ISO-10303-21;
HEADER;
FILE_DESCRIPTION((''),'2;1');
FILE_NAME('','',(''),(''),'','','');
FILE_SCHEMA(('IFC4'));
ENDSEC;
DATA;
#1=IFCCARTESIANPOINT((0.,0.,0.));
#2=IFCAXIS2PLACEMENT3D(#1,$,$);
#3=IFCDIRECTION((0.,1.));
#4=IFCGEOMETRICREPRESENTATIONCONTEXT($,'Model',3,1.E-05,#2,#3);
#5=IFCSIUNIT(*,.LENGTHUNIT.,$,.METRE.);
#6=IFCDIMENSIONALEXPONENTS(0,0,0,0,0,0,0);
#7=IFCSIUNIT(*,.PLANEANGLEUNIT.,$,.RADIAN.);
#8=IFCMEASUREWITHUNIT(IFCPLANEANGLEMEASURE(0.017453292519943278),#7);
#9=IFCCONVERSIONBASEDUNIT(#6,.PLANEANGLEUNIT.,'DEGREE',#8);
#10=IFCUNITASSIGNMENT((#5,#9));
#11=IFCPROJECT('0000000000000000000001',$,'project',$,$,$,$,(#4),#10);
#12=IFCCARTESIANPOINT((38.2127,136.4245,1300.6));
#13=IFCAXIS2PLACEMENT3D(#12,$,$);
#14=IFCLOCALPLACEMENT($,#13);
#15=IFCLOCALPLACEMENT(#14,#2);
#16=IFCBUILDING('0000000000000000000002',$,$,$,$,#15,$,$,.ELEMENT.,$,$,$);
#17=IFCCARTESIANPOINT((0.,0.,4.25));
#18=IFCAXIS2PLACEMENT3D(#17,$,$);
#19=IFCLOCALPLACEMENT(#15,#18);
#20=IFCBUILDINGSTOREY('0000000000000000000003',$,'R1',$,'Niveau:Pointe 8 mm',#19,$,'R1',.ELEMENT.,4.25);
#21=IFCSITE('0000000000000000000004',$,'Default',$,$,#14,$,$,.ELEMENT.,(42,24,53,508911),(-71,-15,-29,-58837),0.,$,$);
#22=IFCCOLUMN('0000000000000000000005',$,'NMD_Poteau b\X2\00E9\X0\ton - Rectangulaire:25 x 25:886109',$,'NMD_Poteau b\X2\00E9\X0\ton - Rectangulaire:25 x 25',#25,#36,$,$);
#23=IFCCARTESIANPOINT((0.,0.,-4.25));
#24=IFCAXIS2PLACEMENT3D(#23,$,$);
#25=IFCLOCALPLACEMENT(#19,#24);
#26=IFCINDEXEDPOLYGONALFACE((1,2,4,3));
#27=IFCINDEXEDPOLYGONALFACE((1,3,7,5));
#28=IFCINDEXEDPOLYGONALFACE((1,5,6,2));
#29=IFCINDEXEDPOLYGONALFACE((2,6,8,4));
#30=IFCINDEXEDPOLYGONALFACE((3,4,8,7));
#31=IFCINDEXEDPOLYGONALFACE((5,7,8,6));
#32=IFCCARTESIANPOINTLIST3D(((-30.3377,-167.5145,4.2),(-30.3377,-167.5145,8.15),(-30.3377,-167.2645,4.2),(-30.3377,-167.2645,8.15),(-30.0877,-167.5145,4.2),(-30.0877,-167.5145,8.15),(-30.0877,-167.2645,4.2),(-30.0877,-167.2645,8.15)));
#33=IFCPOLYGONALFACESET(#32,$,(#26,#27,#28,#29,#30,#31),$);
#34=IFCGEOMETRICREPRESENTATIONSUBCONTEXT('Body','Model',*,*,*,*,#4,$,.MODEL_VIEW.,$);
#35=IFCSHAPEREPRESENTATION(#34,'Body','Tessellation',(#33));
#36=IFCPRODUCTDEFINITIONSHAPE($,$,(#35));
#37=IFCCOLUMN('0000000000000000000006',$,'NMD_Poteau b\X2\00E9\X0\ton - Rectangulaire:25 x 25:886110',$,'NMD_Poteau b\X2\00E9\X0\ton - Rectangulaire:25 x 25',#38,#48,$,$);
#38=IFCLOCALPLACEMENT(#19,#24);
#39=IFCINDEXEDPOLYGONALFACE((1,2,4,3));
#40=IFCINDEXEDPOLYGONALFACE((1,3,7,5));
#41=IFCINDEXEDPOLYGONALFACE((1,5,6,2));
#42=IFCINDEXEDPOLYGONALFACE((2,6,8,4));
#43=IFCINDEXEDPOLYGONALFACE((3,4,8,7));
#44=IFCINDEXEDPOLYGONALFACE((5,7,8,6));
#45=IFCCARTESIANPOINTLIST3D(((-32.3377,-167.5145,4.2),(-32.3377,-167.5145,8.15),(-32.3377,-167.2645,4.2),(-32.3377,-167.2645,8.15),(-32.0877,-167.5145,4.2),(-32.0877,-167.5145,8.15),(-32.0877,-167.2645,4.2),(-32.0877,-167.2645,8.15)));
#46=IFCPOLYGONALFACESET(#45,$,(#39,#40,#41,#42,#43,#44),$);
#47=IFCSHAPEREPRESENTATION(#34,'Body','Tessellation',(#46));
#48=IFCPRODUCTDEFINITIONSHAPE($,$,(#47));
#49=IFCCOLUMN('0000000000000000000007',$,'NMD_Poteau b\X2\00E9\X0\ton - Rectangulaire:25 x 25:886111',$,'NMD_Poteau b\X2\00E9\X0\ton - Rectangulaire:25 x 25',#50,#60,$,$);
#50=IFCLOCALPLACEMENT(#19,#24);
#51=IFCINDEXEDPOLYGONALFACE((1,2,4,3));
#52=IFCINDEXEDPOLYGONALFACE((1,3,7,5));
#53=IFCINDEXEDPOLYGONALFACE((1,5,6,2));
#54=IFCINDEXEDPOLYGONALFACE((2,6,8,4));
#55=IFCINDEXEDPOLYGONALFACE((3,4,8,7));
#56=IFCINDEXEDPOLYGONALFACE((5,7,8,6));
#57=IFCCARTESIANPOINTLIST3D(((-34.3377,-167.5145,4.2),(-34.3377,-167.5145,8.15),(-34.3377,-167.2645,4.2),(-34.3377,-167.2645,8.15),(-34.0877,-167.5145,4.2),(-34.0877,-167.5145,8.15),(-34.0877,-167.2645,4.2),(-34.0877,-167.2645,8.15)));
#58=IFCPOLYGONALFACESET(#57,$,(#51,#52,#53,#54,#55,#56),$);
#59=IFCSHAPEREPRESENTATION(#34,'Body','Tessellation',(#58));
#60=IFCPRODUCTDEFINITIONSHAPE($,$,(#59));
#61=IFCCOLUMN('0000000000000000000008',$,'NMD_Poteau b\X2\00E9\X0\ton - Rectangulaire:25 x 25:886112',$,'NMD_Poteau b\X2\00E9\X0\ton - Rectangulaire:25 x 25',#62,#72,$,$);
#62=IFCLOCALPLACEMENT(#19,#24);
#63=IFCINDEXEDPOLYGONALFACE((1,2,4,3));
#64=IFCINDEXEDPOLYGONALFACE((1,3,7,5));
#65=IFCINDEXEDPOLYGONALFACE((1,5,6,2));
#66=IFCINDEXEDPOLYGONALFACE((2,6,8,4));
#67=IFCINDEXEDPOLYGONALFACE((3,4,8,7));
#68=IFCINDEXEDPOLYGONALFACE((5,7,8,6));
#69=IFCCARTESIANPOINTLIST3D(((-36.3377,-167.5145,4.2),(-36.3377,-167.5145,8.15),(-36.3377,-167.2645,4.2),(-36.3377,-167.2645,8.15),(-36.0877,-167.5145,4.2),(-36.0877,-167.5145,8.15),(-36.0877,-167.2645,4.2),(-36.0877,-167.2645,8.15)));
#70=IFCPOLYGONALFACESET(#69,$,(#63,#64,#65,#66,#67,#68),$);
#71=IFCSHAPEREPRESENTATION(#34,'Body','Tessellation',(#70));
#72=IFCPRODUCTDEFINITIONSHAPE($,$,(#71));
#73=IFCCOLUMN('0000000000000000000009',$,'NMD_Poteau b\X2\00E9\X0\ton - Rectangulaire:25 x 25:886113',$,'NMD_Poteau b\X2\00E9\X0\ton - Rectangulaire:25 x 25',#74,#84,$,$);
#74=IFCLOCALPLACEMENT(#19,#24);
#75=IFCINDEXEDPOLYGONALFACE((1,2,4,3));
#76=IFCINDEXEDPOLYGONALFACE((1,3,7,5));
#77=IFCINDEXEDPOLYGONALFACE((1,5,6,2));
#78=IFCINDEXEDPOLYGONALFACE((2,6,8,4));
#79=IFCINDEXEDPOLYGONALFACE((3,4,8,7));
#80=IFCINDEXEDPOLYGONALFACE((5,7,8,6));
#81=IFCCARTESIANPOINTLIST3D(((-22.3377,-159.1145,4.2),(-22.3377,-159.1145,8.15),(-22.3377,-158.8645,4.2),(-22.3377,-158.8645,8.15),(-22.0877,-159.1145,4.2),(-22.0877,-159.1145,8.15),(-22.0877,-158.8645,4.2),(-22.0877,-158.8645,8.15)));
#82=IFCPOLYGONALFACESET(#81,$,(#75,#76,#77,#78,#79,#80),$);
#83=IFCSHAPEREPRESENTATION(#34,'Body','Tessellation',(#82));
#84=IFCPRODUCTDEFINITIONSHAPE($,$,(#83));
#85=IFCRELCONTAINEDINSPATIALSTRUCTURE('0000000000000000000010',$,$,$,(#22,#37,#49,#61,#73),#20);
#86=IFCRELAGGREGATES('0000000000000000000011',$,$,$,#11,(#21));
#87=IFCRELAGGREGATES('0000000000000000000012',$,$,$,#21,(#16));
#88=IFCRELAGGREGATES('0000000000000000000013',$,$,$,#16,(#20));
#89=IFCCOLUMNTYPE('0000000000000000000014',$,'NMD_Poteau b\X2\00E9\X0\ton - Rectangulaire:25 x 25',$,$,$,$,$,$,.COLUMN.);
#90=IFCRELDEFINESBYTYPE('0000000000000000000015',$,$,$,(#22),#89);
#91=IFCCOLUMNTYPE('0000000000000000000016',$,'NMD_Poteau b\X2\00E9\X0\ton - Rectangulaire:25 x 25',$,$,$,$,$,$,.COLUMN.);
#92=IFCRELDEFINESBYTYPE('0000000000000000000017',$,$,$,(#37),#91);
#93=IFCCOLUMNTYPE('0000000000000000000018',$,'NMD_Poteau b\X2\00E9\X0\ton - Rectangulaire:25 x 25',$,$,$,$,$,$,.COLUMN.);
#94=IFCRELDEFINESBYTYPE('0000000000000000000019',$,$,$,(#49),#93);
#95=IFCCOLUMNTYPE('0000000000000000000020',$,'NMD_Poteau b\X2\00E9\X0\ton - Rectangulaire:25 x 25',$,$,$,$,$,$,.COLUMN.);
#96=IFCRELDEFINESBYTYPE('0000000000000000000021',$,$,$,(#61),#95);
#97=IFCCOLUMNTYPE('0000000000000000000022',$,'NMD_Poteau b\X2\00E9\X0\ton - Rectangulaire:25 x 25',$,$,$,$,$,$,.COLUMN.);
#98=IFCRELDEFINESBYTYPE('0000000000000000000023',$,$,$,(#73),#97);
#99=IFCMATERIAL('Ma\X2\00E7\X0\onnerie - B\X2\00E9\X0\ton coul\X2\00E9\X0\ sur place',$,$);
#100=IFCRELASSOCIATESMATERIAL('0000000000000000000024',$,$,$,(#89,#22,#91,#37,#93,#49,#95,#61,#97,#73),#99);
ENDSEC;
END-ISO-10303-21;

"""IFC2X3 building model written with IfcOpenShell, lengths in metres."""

from ifc_helpers import new_model, entity, si_unit, converted_unit, direction, frame, frame_2d, origin, place, context, subcontext, project, spatial, rectangle, extrude, source, transform, mapped, material, type_object, type_shapes, element, save


model = new_model("IFC2X3")

# Units and contexts
model_context = context("Model", 3, precision=1e-05, world=origin(), true_north=direction((0.0, 1.0)))
body_context = subcontext(model_context, "Body", "Model", "MODEL_VIEW")
ifc_project = project(units=[si_unit("LENGTHUNIT", "METRE"), converted_unit("PLANEANGLEUNIT", "DEGREE", entity("IfcPlaneAngleMeasure", 0.017453292519943278), si_unit("PLANEANGLEUNIT", "RADIAN"), dimensions=[0, 0, 0, 0, 0, 0, 0])], contexts=[model_context])

# Site, building, storey
site_placement = place(None, frame((38.2127, 136.4245, 1300.6)))
site = spatial("IfcSite", under=ifc_project, at=site_placement, Name="Default", CompositionType="ELEMENT", RefLatitude=(42, 24, 53, 508911), RefLongitude=(-71, -15, -29, -58837), RefElevation=0.0)
building_placement = place(site_placement, origin())
building = spatial("IfcBuilding", under=site, at=building_placement, CompositionType="ELEMENT")
storey_placement = place(building_placement, frame((0.0, 0.0, 4.25)))
storey = spatial("IfcBuildingStorey", under=building, at=storey_placement, Name="R1", ObjectType="Niveau:Pointe 8 mm", LongName="R1", CompositionType="ELEMENT", Elevation=4.25)

# Columns
ifc_material = material(Name="Maçonnerie - Béton coulé sur place")
column_type_1 = type_object("IfcColumnType", Name="NMD_Poteau béton - Rectangulaire:25 x 25", PredefinedType="COLUMN", material=ifc_material)
shared_shape_1 = source(origin(), body_context, "Body", "SweptSolid", [
    extrude(rectangle(XDim=0.25, YDim=0.25, at=frame_2d((0.0, 0.0), x_axis=(1.0, 0.0))), frame((-30.2127, -167.3895, 4.2), z_axis=(0.0, 0.0, 1.0), x_axis=(-1.0, 0.0, 0.0)), (0.0, 0.0, 1.0), 3.95),
])
type_shapes(column_type_1, [shared_shape_1])
column_1_placement = place(storey_placement, frame((0.0, 0.0, -4.25)))
element("IfcColumn", 1, at=column_1_placement, inside=storey, type_object=column_type_1, material=ifc_material, Name="NMD_Poteau béton - Rectangulaire:25 x 25:886109", ObjectType="NMD_Poteau béton - Rectangulaire:25 x 25", context=body_context, shape_type="MappedRepresentation", body=[
    mapped(shared_shape_1, transform((0.0, 0.0, 0.0), scale=1.0)),
])
column_type_2 = type_object("IfcColumnType", Name="NMD_Poteau béton - Rectangulaire:25 x 25", PredefinedType="COLUMN", material=ifc_material)
shared_shape_2 = source(origin(), body_context, "Body", "SweptSolid", [
    extrude(rectangle(XDim=0.25, YDim=0.25, at=frame_2d((0.0, 0.0), x_axis=(1.0, 0.0))), frame((-32.2127, -167.3895, 4.2), z_axis=(0.0, 0.0, 1.0), x_axis=(-1.0, 0.0, 0.0)), (0.0, 0.0, 1.0), 3.95),
])
type_shapes(column_type_2, [shared_shape_2])
column_2_placement = place(storey_placement, frame((0.0, 0.0, -4.25)))
element("IfcColumn", 2, at=column_2_placement, inside=storey, type_object=column_type_2, material=ifc_material, Name="NMD_Poteau béton - Rectangulaire:25 x 25:886110", ObjectType="NMD_Poteau béton - Rectangulaire:25 x 25", context=body_context, shape_type="MappedRepresentation", body=[
    mapped(shared_shape_2, transform((0.0, 0.0, 0.0), scale=1.0)),
])
column_type_3 = type_object("IfcColumnType", Name="NMD_Poteau béton - Rectangulaire:25 x 25", PredefinedType="COLUMN", material=ifc_material)
shared_shape_3 = source(origin(), body_context, "Body", "SweptSolid", [
    extrude(rectangle(XDim=0.25, YDim=0.25, at=frame_2d((0.0, 0.0), x_axis=(1.0, 0.0))), frame((-34.2127, -167.3895, 4.2), z_axis=(0.0, 0.0, 1.0), x_axis=(-1.0, 0.0, 0.0)), (0.0, 0.0, 1.0), 3.95),
])
type_shapes(column_type_3, [shared_shape_3])
column_3_placement = place(storey_placement, frame((0.0, 0.0, -4.25)))
element("IfcColumn", 3, at=column_3_placement, inside=storey, type_object=column_type_3, material=ifc_material, Name="NMD_Poteau béton - Rectangulaire:25 x 25:886111", ObjectType="NMD_Poteau béton - Rectangulaire:25 x 25", context=body_context, shape_type="MappedRepresentation", body=[
    mapped(shared_shape_3, transform((0.0, 0.0, 0.0), scale=1.0)),
])
column_type_4 = type_object("IfcColumnType", Name="NMD_Poteau béton - Rectangulaire:25 x 25", PredefinedType="COLUMN", material=ifc_material)
shared_shape_4 = source(origin(), body_context, "Body", "SweptSolid", [
    extrude(rectangle(XDim=0.25, YDim=0.25, at=frame_2d((0.0, 0.0), x_axis=(1.0, 0.0))), frame((-36.2127, -167.3895, 4.2), z_axis=(0.0, 0.0, 1.0), x_axis=(-1.0, 0.0, 0.0)), (0.0, 0.0, 1.0), 3.95),
])
type_shapes(column_type_4, [shared_shape_4])
column_4_placement = place(storey_placement, frame((0.0, 0.0, -4.25)))
element("IfcColumn", 4, at=column_4_placement, inside=storey, type_object=column_type_4, material=ifc_material, Name="NMD_Poteau béton - Rectangulaire:25 x 25:886112", ObjectType="NMD_Poteau béton - Rectangulaire:25 x 25", context=body_context, shape_type="MappedRepresentation", body=[
    mapped(shared_shape_4, transform((0.0, 0.0, 0.0), scale=1.0)),
])
column_type_5 = type_object("IfcColumnType", Name="NMD_Poteau béton - Rectangulaire:25 x 25", PredefinedType="COLUMN", material=ifc_material)
shared_shape_5 = source(origin(), body_context, "Body", "SweptSolid", [
    extrude(rectangle(XDim=0.25, YDim=0.25, at=frame_2d((0.0, 0.0), x_axis=(1.0, 0.0))), frame((-22.2127, -158.9895, 4.2), z_axis=(0.0, 0.0, 1.0), x_axis=(-1.0, 0.0, 0.0)), (0.0, 0.0, 1.0), 3.95),
])
type_shapes(column_type_5, [shared_shape_5])
column_5_placement = place(storey_placement, frame((0.0, 0.0, -4.25)))
element("IfcColumn", 5, at=column_5_placement, inside=storey, type_object=column_type_5, material=ifc_material, Name="NMD_Poteau béton - Rectangulaire:25 x 25:886113", ObjectType="NMD_Poteau béton - Rectangulaire:25 x 25", context=body_context, shape_type="MappedRepresentation", body=[
    mapped(shared_shape_5, transform((0.0, 0.0, 0.0), scale=1.0)),
])

save(model, "model.ifc")
